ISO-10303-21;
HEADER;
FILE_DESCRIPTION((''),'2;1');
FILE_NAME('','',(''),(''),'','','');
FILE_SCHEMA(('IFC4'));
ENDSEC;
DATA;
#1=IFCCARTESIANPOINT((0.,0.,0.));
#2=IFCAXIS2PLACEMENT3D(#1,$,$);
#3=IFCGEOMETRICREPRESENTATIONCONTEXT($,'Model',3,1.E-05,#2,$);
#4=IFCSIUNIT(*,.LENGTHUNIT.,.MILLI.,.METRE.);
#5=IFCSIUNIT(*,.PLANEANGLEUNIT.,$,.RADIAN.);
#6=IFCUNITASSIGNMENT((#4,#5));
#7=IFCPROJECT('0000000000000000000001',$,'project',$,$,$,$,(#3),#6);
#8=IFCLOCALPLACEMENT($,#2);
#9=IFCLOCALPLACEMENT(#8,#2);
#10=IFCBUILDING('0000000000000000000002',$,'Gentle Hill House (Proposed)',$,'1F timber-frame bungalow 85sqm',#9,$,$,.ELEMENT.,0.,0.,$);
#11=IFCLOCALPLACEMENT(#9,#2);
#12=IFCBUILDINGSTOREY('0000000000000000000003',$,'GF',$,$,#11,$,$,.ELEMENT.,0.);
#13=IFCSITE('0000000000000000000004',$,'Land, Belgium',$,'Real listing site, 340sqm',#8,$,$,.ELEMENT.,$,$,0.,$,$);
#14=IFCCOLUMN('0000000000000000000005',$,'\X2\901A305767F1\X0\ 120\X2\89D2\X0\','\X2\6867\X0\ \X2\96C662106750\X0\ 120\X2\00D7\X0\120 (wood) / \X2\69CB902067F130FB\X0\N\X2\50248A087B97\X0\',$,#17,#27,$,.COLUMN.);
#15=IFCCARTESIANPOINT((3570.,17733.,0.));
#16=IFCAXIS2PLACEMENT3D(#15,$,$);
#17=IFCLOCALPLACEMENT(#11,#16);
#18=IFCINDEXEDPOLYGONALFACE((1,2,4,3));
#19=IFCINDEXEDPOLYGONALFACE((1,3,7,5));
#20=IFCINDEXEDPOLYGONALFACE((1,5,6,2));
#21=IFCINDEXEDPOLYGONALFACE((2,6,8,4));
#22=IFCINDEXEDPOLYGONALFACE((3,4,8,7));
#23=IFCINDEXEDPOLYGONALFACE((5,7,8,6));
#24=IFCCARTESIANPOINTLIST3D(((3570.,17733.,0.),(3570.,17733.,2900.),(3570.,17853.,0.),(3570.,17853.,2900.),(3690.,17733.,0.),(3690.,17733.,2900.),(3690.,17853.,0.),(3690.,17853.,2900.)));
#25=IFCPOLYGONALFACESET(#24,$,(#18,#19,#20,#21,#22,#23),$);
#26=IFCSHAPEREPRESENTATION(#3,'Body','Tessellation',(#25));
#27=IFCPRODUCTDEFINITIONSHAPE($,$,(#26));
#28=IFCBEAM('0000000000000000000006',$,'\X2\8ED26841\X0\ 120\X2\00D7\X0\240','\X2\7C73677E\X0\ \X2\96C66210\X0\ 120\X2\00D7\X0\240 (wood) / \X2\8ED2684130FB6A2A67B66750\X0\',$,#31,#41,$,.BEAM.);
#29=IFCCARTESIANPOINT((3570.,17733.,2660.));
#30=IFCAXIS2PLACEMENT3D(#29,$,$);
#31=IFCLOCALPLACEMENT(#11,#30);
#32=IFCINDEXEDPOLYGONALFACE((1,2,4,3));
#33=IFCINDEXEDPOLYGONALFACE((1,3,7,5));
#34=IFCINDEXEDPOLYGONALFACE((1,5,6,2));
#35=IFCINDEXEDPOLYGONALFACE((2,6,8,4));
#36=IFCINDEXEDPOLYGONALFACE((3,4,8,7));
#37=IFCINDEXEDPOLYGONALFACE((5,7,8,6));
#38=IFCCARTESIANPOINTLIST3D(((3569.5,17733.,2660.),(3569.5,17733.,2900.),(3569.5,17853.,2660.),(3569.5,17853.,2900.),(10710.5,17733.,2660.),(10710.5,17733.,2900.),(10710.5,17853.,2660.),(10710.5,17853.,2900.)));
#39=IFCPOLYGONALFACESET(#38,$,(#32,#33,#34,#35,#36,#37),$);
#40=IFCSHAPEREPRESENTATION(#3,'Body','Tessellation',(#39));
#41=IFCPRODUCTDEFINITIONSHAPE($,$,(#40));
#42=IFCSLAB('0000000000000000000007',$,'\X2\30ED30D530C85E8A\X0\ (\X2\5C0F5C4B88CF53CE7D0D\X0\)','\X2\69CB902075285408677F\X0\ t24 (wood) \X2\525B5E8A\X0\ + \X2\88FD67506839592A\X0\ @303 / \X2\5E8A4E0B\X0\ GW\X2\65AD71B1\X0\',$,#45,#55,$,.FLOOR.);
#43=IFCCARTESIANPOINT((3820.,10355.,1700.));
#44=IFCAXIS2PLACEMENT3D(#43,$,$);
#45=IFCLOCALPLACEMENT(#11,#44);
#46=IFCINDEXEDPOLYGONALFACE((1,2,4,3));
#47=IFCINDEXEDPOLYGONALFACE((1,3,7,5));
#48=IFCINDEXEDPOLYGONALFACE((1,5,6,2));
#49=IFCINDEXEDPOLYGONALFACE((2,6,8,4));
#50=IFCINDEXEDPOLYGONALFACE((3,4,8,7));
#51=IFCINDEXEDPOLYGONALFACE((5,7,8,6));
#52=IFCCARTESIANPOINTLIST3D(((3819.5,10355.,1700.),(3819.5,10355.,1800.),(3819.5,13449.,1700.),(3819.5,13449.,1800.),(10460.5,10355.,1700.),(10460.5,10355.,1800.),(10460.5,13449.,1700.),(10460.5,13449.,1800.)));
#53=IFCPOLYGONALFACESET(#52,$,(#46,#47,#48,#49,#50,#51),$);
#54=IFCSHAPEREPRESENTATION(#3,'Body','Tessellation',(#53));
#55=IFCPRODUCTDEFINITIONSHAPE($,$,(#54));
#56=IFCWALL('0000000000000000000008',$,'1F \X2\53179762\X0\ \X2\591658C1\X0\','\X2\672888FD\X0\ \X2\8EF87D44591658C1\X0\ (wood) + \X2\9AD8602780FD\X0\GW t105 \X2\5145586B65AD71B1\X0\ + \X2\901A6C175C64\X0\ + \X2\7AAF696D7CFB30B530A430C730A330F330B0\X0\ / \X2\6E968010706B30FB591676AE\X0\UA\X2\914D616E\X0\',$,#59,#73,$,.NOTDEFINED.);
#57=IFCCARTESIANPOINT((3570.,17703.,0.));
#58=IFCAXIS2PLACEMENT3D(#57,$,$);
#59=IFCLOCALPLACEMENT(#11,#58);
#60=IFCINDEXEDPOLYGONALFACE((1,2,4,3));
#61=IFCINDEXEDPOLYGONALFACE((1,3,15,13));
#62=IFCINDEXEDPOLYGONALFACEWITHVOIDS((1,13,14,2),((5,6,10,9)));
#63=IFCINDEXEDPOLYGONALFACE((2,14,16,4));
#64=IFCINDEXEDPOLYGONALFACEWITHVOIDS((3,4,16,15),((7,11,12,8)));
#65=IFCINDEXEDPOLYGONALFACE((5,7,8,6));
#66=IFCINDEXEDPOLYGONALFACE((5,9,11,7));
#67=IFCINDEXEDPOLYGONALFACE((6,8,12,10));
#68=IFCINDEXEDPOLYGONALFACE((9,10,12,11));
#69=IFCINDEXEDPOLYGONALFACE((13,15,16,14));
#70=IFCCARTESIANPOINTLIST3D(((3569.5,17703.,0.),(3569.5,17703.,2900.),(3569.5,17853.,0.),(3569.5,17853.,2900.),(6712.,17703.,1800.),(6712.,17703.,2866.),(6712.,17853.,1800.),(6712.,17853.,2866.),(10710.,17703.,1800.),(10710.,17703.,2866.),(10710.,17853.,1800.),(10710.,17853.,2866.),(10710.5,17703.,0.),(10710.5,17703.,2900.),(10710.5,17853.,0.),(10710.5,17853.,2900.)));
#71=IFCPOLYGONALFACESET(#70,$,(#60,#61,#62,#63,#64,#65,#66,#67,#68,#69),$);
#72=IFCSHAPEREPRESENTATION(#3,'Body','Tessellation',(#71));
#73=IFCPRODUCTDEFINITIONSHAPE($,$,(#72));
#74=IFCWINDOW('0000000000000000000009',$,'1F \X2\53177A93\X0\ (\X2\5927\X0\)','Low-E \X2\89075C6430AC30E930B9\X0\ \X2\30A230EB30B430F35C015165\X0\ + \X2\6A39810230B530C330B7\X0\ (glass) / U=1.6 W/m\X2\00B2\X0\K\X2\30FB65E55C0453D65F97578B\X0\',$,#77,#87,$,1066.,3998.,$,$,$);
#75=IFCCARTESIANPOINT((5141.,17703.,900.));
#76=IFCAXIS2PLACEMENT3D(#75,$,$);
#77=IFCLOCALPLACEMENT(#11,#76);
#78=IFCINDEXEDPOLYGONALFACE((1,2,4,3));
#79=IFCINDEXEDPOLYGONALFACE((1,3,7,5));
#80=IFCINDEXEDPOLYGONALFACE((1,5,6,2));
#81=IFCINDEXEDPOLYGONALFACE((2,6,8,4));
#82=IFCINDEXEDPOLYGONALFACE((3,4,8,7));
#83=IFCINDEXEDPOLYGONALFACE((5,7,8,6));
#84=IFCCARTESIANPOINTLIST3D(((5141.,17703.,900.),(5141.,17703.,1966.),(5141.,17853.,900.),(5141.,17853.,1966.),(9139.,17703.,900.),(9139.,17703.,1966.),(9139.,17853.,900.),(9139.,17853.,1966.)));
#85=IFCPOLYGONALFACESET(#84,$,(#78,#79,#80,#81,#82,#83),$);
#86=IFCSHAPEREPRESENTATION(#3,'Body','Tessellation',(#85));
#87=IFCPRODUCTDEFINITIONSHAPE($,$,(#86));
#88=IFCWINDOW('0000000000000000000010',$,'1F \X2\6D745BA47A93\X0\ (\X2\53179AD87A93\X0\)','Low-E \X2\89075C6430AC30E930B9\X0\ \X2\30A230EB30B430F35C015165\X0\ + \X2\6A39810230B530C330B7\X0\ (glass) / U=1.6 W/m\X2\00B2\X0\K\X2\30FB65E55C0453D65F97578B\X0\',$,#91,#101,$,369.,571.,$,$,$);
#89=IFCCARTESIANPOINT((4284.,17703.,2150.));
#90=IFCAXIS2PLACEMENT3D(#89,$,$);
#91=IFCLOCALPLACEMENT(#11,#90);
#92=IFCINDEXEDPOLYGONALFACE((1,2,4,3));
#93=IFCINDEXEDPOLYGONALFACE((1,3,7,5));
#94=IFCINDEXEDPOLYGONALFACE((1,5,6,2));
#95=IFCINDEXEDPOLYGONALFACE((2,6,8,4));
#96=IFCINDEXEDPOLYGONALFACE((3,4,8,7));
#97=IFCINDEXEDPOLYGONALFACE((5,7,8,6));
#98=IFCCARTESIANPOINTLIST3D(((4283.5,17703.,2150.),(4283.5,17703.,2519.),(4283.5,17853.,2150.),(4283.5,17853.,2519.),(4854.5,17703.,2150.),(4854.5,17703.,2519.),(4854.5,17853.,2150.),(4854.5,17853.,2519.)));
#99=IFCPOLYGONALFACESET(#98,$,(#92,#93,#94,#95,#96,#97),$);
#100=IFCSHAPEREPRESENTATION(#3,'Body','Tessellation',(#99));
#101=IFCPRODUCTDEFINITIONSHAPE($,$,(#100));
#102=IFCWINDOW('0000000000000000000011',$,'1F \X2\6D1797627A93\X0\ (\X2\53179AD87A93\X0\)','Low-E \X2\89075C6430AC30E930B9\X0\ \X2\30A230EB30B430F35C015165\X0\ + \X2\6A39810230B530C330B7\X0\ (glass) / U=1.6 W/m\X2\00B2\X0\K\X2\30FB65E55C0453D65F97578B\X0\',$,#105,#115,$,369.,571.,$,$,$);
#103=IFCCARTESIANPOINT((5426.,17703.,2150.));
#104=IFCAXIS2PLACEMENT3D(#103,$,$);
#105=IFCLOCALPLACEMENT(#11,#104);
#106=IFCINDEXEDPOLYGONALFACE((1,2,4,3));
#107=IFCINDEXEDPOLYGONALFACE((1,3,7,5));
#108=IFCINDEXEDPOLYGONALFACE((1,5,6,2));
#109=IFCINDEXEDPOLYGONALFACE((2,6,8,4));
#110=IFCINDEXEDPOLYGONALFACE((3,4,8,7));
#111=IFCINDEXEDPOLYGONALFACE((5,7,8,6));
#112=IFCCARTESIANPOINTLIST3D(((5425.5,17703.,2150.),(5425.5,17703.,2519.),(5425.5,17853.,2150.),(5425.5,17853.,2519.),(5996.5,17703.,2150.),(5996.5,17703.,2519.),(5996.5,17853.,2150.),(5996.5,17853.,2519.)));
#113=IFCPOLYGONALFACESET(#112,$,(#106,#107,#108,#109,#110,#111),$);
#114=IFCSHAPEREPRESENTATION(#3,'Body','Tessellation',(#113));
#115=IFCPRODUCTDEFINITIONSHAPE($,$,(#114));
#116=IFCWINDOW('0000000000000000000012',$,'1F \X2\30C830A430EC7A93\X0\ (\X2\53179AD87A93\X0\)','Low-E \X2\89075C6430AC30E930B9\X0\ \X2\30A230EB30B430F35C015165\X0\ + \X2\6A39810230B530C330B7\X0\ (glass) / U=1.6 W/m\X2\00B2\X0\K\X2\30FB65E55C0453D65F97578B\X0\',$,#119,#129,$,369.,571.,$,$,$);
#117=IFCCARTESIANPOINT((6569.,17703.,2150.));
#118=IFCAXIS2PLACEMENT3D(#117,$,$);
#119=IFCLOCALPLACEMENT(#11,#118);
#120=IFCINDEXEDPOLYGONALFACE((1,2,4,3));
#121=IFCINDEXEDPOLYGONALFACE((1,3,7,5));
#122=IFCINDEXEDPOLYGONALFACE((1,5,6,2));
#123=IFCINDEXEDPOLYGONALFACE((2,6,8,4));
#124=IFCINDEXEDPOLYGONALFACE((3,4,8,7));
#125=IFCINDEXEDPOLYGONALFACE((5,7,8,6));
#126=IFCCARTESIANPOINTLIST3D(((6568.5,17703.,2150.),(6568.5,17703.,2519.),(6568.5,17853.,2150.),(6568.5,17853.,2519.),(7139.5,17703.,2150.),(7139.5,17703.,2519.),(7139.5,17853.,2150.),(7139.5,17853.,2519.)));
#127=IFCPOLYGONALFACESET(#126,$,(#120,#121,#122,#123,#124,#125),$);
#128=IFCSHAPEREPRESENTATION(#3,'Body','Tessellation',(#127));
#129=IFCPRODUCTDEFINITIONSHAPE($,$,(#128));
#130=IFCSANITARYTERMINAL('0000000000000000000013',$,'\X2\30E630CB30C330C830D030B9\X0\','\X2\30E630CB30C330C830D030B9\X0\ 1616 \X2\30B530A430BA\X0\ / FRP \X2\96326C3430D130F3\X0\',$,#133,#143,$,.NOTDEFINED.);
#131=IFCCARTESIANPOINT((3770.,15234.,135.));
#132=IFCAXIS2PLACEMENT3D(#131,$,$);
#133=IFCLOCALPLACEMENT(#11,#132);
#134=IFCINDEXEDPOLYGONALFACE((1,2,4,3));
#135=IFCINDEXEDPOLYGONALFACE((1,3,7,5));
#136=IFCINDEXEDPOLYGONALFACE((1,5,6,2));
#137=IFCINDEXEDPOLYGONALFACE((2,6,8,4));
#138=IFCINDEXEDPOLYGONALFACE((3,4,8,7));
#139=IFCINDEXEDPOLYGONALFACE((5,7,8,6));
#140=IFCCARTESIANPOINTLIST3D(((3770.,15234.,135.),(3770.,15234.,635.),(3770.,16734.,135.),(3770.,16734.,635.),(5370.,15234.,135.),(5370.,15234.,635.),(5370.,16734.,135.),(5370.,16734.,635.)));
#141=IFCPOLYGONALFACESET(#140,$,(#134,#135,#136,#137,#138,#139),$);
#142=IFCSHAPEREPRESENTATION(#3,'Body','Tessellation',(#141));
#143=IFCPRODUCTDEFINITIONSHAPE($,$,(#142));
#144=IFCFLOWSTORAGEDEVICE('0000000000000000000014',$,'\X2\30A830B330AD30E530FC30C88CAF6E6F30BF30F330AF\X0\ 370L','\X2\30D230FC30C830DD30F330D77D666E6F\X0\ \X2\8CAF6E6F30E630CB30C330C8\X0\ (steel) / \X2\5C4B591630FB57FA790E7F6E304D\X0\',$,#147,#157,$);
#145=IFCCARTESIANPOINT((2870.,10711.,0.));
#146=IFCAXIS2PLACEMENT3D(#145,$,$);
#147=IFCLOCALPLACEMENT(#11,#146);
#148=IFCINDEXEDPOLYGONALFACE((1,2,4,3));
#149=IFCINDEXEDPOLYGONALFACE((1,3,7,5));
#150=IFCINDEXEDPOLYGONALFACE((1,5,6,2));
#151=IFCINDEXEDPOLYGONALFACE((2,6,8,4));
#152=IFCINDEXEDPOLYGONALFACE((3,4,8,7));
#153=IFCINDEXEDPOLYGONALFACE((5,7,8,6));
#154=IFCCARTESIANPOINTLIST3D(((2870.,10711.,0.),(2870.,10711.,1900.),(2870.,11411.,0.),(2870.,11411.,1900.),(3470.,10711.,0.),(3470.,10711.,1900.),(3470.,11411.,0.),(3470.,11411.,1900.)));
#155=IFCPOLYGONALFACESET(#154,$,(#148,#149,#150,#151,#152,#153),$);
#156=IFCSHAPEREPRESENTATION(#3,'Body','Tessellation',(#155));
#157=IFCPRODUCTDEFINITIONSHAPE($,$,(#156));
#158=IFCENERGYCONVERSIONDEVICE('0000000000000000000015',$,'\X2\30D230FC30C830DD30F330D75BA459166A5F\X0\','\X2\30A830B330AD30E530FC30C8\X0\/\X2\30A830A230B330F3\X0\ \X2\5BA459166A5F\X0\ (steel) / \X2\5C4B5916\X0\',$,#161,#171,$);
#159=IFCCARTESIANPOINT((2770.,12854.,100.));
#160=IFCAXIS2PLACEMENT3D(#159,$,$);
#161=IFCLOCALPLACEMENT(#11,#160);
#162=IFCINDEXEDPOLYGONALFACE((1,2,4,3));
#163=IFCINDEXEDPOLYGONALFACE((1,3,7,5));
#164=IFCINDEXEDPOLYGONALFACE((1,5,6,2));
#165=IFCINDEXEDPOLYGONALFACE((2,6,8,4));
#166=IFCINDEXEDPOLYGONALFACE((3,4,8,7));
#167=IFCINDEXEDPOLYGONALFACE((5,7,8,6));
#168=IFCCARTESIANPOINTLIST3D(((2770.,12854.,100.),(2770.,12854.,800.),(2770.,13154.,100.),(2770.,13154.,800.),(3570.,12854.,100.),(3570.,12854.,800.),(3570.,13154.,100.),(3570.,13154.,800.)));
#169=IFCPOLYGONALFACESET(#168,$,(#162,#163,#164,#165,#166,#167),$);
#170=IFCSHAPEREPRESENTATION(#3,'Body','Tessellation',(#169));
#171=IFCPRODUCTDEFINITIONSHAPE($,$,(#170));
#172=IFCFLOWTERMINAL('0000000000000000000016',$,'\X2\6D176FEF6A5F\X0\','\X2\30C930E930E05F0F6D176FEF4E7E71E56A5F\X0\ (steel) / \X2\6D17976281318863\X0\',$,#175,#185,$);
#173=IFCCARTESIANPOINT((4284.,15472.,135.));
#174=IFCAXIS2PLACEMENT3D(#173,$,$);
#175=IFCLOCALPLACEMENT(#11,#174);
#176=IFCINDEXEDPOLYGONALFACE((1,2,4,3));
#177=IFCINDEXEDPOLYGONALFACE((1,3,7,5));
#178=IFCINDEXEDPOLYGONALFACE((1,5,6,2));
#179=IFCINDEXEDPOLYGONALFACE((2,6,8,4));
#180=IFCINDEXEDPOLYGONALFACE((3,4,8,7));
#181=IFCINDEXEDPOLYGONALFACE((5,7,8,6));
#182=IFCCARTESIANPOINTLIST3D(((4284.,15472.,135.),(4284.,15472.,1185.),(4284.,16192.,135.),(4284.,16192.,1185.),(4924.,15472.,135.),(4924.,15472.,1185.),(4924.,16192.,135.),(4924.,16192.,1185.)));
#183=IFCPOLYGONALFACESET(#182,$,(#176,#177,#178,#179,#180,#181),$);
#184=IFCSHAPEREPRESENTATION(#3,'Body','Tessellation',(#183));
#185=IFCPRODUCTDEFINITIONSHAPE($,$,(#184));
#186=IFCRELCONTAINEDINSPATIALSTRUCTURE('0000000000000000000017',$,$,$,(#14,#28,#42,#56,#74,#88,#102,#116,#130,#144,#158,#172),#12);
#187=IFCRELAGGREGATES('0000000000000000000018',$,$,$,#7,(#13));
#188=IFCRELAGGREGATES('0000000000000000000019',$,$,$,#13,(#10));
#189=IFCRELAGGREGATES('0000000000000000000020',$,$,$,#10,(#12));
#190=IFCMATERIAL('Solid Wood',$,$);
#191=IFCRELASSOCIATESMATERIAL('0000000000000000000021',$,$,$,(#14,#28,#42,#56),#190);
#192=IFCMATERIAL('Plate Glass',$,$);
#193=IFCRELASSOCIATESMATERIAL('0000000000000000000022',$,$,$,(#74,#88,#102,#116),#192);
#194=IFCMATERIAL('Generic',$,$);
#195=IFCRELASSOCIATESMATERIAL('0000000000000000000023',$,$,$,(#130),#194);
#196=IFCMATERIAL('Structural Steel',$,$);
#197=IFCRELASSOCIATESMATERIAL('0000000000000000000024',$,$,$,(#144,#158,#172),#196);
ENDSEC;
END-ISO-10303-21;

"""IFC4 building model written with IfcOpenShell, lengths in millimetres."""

from ifc_helpers import new_model, si_unit, frame, frame_2d, origin, place, context, project, spatial, rectangle, extrude, material, element, fill, save


model = new_model("IFC4")

# Units and contexts
model_context = context("Model", 3, precision=1e-05, world=origin())
ifc_project = project(units=[si_unit("LENGTHUNIT", "METRE", prefix="MILLI"), si_unit("PLANEANGLEUNIT", "RADIAN")], contexts=[model_context])

# Site, building, storey
site_placement = place(None, origin())
site = spatial("IfcSite", under=ifc_project, at=site_placement, Name="Land, Belgium", ObjectType="Real listing site, 340sqm", CompositionType="ELEMENT", RefElevation=0.0)
building_placement = place(site_placement, origin())
building = spatial("IfcBuilding", under=site, at=building_placement, Name="Gentle Hill House (Proposed)", ObjectType="1F timber-frame bungalow 85sqm", CompositionType="ELEMENT", ElevationOfRefHeight=0.0, ElevationOfTerrain=0.0)
storey_placement = place(building_placement, origin())
storey = spatial("IfcBuildingStorey", under=building, at=storey_placement, Name="GF", CompositionType="ELEMENT", Elevation=0.0)

# Column
ifc_material_1 = material(Name="Solid Wood")
column_1_placement = place(storey_placement, frame((3570.0, 17733.0, 0.0)))
element("IfcColumn", 1, at=column_1_placement, inside=storey, material=ifc_material_1, Name="通し柱 120角", Description="桧 集成材 120×120 (wood) / 構造柱・N値計算", PredefinedType="COLUMN", context=model_context, shape_type="SweptSolid", body=[
    extrude(rectangle(XDim=120.0, YDim=120.0, at=frame_2d((60.0, 60.0))), frame((3570.0, 17733.0, 0.0)), (0.0, 0.0, 1.0), 2900.0),
])

# Beam
beam_1_placement = place(storey_placement, frame((3570.0, 17733.0, 2660.0)))
element("IfcBeam", 2, at=beam_1_placement, inside=storey, material=ifc_material_1, Name="軒桁 120×240", Description="米松 集成 120×240 (wood) / 軒桁・横架材", PredefinedType="BEAM", context=model_context, shape_type="SweptSolid", body=[
    extrude(rectangle(XDim=7141.0, YDim=120.0, at=frame_2d((3570.0, 60.0))), frame((3570.0, 17733.0, 2660.0)), (0.0, 0.0, 1.0), 240.0),
])

# Slab
slab_placement = place(storey_placement, frame((3820.0, 10355.0, 1700.0)))
element("IfcSlab", 3, at=slab_placement, inside=storey, material=ifc_material_1, Name="ロフト床 (小屋裏収納)", Description="構造用合板 t24 (wood) 剛床 + 製材根太 @303 / 床下 GW断熱", PredefinedType="FLOOR", context=model_context, shape_type="SweptSolid", body=[
    extrude(rectangle(XDim=6641.0, YDim=3094.0, at=frame_2d((3320.0, 1547.0))), frame((3820.0, 10355.0, 1700.0)), (0.0, 0.0, 1.0), 100.0),
])

# Wall, openings, windows
wall_1_placement = place(storey_placement, frame((3570.0, 17703.0, 0.0)))
wall_1 = element("IfcWall", 4, at=wall_1_placement, inside=storey, material=ifc_material_1, Name="1F 北面 外壁", Description="木製 軸組外壁 (wood) + 高性能GW t105 充填断熱 + 通気層 + 窯業系サイディング / 準耐火・外皮UA配慮", PredefinedType="NOTDEFINED", context=model_context, shape_type="SweptSolid", body=[
    extrude(rectangle(XDim=7141.0, YDim=150.0, at=frame_2d((3570.0, 75.0))), frame((3570.0, 17703.0, 0.0)), (0.0, 0.0, 1.0), 2900.0),
])
opening_1_placement = place(storey_placement, frame((5141.0, 17703.0, 900.0)))
opening_1 = element("IfcOpeningElement", 5, at=opening_1_placement, cuts=wall_1, PredefinedType="NOTDEFINED", context=model_context, shape_type="SweptSolid", body=[
    extrude(rectangle(XDim=3998.0, YDim=150.0, at=frame_2d((1999.0, 75.0))), frame((5141.0, 17703.0, 900.0)), (0.0, 0.0, 1.0), 1066.0),
])
opening_2_placement = place(storey_placement, frame((4284.0, 17703.0, 2150.0)))
opening_2 = element("IfcOpeningElement", 6, at=opening_2_placement, cuts=wall_1, PredefinedType="NOTDEFINED", context=model_context, shape_type="SweptSolid", body=[
    extrude(rectangle(XDim=571.0, YDim=150.0, at=frame_2d((285.0, 75.0))), frame((4284.0, 17703.0, 2150.0)), (0.0, 0.0, 1.0), 369.0),
])
opening_3_placement = place(storey_placement, frame((5426.0, 17703.0, 2150.0)))
opening_3 = element("IfcOpeningElement", 7, at=opening_3_placement, cuts=wall_1, PredefinedType="NOTDEFINED", context=model_context, shape_type="SweptSolid", body=[
    extrude(rectangle(XDim=571.0, YDim=150.0, at=frame_2d((285.0, 75.0))), frame((5426.0, 17703.0, 2150.0)), (0.0, 0.0, 1.0), 369.0),
])
opening_4_placement = place(storey_placement, frame((6569.0, 17703.0, 2150.0)))
opening_4 = element("IfcOpeningElement", 8, at=opening_4_placement, cuts=wall_1, PredefinedType="NOTDEFINED", context=model_context, shape_type="SweptSolid", body=[
    extrude(rectangle(XDim=571.0, YDim=150.0, at=frame_2d((285.0, 75.0))), frame((6569.0, 17703.0, 2150.0)), (0.0, 0.0, 1.0), 369.0),
])
ifc_material_2 = material(Name="Plate Glass")
window_1_placement = place(storey_placement, frame((5141.0, 17703.0, 900.0)))
window_1 = element("IfcWindow", 9, at=window_1_placement, inside=storey, material=ifc_material_2, Name="1F 北窓 (大)", Description="Low-E 複層ガラス アルゴン封入 + 樹脂サッシ (glass) / U=1.6 W/m²K・日射取得型", OverallHeight=1066.0, OverallWidth=3998.0, context=model_context, shape_type="SweptSolid", body=[
    extrude(rectangle(XDim=3998.0, YDim=150.0, at=frame_2d((1999.0, 75.0))), frame((5141.0, 17703.0, 900.0)), (0.0, 0.0, 1.0), 1066.0),
])
fill(opening_1, window_1)
window_2_placement = place(storey_placement, frame((4284.0, 17703.0, 2150.0)))
window_2 = element("IfcWindow", 10, at=window_2_placement, inside=storey, material=ifc_material_2, Name="1F 浴室窓 (北高窓)", Description="Low-E 複層ガラス アルゴン封入 + 樹脂サッシ (glass) / U=1.6 W/m²K・日射取得型", OverallHeight=369.0, OverallWidth=571.0, context=model_context, shape_type="SweptSolid", body=[
    extrude(rectangle(XDim=571.0, YDim=150.0, at=frame_2d((285.0, 75.0))), frame((4284.0, 17703.0, 2150.0)), (0.0, 0.0, 1.0), 369.0),
])
fill(opening_2, window_2)
window_3_placement = place(storey_placement, frame((5426.0, 17703.0, 2150.0)))
window_3 = element("IfcWindow", 11, at=window_3_placement, inside=storey, material=ifc_material_2, Name="1F 洗面窓 (北高窓)", Description="Low-E 複層ガラス アルゴン封入 + 樹脂サッシ (glass) / U=1.6 W/m²K・日射取得型", OverallHeight=369.0, OverallWidth=571.0, context=model_context, shape_type="SweptSolid", body=[
    extrude(rectangle(XDim=571.0, YDim=150.0, at=frame_2d((285.0, 75.0))), frame((5426.0, 17703.0, 2150.0)), (0.0, 0.0, 1.0), 369.0),
])
fill(opening_3, window_3)
window_4_placement = place(storey_placement, frame((6569.0, 17703.0, 2150.0)))
window_4 = element("IfcWindow", 12, at=window_4_placement, inside=storey, material=ifc_material_2, Name="1F トイレ窓 (北高窓)", Description="Low-E 複層ガラス アルゴン封入 + 樹脂サッシ (glass) / U=1.6 W/m²K・日射取得型", OverallHeight=369.0, OverallWidth=571.0, context=model_context, shape_type="SweptSolid", body=[
    extrude(rectangle(XDim=571.0, YDim=150.0, at=frame_2d((285.0, 75.0))), frame((6569.0, 17703.0, 2150.0)), (0.0, 0.0, 1.0), 369.0),
])
fill(opening_4, window_4)

# Sanitary terminal
ifc_material_3 = material(Name="Generic")
sanitary_terminal_placement = place(storey_placement, frame((3770.0, 15234.0, 135.0)))
element("IfcSanitaryTerminal", 13, at=sanitary_terminal_placement, inside=storey, material=ifc_material_3, Name="ユニットバス", Description="ユニットバス 1616 サイズ / FRP 防水パン", PredefinedType="NOTDEFINED", context=model_context, shape_type="SweptSolid", body=[
    extrude(rectangle(XDim=1600.0, YDim=1500.0, at=frame_2d((800.0, 750.0))), frame((3770.0, 15234.0, 135.0)), (0.0, 0.0, 1.0), 500.0),
])

# Flow storage device
ifc_material_4 = material(Name="Structural Steel")
flow_storage_device_placement = place(storey_placement, frame((2870.0, 10711.0, 0.0)))
element("IfcFlowStorageDevice", 14, at=flow_storage_device_placement, inside=storey, material=ifc_material_4, Name="エコキュート貯湯タンク 370L", Description="ヒートポンプ給湯 貯湯ユニット (steel) / 屋外・基礎置き", context=model_context, shape_type="SweptSolid", body=[
    extrude(rectangle(XDim=600.0, YDim=700.0, at=frame_2d((300.0, 350.0))), frame((2870.0, 10711.0, 0.0)), (0.0, 0.0, 1.0), 1900.0),
])

# Energy conversion device
energy_conversion_device_placement = place(storey_placement, frame((2770.0, 12854.0, 100.0)))
element("IfcEnergyConversionDevice", 15, at=energy_conversion_device_placement, inside=storey, material=ifc_material_4, Name="ヒートポンプ室外機", Description="エコキュート/エアコン 室外機 (steel) / 屋外", context=model_context, shape_type="SweptSolid", body=[
    extrude(rectangle(XDim=800.0, YDim=300.0, at=frame_2d((400.0, 150.0))), frame((2770.0, 12854.0, 100.0)), (0.0, 0.0, 1.0), 700.0),
])

# Flow terminal
flow_terminal_placement = place(storey_placement, frame((4284.0, 15472.0, 135.0)))
element("IfcFlowTerminal", 16, at=flow_terminal_placement, inside=storey, material=ifc_material_4, Name="洗濯機", Description="ドラム式洗濯乾燥機 (steel) / 洗面脱衣", context=model_context, shape_type="SweptSolid", body=[
    extrude(rectangle(XDim=640.0, YDim=720.0, at=frame_2d((320.0, 360.0))), frame((4284.0, 15472.0, 135.0)), (0.0, 0.0, 1.0), 1050.0),
])

save(model, "model.ifc")
